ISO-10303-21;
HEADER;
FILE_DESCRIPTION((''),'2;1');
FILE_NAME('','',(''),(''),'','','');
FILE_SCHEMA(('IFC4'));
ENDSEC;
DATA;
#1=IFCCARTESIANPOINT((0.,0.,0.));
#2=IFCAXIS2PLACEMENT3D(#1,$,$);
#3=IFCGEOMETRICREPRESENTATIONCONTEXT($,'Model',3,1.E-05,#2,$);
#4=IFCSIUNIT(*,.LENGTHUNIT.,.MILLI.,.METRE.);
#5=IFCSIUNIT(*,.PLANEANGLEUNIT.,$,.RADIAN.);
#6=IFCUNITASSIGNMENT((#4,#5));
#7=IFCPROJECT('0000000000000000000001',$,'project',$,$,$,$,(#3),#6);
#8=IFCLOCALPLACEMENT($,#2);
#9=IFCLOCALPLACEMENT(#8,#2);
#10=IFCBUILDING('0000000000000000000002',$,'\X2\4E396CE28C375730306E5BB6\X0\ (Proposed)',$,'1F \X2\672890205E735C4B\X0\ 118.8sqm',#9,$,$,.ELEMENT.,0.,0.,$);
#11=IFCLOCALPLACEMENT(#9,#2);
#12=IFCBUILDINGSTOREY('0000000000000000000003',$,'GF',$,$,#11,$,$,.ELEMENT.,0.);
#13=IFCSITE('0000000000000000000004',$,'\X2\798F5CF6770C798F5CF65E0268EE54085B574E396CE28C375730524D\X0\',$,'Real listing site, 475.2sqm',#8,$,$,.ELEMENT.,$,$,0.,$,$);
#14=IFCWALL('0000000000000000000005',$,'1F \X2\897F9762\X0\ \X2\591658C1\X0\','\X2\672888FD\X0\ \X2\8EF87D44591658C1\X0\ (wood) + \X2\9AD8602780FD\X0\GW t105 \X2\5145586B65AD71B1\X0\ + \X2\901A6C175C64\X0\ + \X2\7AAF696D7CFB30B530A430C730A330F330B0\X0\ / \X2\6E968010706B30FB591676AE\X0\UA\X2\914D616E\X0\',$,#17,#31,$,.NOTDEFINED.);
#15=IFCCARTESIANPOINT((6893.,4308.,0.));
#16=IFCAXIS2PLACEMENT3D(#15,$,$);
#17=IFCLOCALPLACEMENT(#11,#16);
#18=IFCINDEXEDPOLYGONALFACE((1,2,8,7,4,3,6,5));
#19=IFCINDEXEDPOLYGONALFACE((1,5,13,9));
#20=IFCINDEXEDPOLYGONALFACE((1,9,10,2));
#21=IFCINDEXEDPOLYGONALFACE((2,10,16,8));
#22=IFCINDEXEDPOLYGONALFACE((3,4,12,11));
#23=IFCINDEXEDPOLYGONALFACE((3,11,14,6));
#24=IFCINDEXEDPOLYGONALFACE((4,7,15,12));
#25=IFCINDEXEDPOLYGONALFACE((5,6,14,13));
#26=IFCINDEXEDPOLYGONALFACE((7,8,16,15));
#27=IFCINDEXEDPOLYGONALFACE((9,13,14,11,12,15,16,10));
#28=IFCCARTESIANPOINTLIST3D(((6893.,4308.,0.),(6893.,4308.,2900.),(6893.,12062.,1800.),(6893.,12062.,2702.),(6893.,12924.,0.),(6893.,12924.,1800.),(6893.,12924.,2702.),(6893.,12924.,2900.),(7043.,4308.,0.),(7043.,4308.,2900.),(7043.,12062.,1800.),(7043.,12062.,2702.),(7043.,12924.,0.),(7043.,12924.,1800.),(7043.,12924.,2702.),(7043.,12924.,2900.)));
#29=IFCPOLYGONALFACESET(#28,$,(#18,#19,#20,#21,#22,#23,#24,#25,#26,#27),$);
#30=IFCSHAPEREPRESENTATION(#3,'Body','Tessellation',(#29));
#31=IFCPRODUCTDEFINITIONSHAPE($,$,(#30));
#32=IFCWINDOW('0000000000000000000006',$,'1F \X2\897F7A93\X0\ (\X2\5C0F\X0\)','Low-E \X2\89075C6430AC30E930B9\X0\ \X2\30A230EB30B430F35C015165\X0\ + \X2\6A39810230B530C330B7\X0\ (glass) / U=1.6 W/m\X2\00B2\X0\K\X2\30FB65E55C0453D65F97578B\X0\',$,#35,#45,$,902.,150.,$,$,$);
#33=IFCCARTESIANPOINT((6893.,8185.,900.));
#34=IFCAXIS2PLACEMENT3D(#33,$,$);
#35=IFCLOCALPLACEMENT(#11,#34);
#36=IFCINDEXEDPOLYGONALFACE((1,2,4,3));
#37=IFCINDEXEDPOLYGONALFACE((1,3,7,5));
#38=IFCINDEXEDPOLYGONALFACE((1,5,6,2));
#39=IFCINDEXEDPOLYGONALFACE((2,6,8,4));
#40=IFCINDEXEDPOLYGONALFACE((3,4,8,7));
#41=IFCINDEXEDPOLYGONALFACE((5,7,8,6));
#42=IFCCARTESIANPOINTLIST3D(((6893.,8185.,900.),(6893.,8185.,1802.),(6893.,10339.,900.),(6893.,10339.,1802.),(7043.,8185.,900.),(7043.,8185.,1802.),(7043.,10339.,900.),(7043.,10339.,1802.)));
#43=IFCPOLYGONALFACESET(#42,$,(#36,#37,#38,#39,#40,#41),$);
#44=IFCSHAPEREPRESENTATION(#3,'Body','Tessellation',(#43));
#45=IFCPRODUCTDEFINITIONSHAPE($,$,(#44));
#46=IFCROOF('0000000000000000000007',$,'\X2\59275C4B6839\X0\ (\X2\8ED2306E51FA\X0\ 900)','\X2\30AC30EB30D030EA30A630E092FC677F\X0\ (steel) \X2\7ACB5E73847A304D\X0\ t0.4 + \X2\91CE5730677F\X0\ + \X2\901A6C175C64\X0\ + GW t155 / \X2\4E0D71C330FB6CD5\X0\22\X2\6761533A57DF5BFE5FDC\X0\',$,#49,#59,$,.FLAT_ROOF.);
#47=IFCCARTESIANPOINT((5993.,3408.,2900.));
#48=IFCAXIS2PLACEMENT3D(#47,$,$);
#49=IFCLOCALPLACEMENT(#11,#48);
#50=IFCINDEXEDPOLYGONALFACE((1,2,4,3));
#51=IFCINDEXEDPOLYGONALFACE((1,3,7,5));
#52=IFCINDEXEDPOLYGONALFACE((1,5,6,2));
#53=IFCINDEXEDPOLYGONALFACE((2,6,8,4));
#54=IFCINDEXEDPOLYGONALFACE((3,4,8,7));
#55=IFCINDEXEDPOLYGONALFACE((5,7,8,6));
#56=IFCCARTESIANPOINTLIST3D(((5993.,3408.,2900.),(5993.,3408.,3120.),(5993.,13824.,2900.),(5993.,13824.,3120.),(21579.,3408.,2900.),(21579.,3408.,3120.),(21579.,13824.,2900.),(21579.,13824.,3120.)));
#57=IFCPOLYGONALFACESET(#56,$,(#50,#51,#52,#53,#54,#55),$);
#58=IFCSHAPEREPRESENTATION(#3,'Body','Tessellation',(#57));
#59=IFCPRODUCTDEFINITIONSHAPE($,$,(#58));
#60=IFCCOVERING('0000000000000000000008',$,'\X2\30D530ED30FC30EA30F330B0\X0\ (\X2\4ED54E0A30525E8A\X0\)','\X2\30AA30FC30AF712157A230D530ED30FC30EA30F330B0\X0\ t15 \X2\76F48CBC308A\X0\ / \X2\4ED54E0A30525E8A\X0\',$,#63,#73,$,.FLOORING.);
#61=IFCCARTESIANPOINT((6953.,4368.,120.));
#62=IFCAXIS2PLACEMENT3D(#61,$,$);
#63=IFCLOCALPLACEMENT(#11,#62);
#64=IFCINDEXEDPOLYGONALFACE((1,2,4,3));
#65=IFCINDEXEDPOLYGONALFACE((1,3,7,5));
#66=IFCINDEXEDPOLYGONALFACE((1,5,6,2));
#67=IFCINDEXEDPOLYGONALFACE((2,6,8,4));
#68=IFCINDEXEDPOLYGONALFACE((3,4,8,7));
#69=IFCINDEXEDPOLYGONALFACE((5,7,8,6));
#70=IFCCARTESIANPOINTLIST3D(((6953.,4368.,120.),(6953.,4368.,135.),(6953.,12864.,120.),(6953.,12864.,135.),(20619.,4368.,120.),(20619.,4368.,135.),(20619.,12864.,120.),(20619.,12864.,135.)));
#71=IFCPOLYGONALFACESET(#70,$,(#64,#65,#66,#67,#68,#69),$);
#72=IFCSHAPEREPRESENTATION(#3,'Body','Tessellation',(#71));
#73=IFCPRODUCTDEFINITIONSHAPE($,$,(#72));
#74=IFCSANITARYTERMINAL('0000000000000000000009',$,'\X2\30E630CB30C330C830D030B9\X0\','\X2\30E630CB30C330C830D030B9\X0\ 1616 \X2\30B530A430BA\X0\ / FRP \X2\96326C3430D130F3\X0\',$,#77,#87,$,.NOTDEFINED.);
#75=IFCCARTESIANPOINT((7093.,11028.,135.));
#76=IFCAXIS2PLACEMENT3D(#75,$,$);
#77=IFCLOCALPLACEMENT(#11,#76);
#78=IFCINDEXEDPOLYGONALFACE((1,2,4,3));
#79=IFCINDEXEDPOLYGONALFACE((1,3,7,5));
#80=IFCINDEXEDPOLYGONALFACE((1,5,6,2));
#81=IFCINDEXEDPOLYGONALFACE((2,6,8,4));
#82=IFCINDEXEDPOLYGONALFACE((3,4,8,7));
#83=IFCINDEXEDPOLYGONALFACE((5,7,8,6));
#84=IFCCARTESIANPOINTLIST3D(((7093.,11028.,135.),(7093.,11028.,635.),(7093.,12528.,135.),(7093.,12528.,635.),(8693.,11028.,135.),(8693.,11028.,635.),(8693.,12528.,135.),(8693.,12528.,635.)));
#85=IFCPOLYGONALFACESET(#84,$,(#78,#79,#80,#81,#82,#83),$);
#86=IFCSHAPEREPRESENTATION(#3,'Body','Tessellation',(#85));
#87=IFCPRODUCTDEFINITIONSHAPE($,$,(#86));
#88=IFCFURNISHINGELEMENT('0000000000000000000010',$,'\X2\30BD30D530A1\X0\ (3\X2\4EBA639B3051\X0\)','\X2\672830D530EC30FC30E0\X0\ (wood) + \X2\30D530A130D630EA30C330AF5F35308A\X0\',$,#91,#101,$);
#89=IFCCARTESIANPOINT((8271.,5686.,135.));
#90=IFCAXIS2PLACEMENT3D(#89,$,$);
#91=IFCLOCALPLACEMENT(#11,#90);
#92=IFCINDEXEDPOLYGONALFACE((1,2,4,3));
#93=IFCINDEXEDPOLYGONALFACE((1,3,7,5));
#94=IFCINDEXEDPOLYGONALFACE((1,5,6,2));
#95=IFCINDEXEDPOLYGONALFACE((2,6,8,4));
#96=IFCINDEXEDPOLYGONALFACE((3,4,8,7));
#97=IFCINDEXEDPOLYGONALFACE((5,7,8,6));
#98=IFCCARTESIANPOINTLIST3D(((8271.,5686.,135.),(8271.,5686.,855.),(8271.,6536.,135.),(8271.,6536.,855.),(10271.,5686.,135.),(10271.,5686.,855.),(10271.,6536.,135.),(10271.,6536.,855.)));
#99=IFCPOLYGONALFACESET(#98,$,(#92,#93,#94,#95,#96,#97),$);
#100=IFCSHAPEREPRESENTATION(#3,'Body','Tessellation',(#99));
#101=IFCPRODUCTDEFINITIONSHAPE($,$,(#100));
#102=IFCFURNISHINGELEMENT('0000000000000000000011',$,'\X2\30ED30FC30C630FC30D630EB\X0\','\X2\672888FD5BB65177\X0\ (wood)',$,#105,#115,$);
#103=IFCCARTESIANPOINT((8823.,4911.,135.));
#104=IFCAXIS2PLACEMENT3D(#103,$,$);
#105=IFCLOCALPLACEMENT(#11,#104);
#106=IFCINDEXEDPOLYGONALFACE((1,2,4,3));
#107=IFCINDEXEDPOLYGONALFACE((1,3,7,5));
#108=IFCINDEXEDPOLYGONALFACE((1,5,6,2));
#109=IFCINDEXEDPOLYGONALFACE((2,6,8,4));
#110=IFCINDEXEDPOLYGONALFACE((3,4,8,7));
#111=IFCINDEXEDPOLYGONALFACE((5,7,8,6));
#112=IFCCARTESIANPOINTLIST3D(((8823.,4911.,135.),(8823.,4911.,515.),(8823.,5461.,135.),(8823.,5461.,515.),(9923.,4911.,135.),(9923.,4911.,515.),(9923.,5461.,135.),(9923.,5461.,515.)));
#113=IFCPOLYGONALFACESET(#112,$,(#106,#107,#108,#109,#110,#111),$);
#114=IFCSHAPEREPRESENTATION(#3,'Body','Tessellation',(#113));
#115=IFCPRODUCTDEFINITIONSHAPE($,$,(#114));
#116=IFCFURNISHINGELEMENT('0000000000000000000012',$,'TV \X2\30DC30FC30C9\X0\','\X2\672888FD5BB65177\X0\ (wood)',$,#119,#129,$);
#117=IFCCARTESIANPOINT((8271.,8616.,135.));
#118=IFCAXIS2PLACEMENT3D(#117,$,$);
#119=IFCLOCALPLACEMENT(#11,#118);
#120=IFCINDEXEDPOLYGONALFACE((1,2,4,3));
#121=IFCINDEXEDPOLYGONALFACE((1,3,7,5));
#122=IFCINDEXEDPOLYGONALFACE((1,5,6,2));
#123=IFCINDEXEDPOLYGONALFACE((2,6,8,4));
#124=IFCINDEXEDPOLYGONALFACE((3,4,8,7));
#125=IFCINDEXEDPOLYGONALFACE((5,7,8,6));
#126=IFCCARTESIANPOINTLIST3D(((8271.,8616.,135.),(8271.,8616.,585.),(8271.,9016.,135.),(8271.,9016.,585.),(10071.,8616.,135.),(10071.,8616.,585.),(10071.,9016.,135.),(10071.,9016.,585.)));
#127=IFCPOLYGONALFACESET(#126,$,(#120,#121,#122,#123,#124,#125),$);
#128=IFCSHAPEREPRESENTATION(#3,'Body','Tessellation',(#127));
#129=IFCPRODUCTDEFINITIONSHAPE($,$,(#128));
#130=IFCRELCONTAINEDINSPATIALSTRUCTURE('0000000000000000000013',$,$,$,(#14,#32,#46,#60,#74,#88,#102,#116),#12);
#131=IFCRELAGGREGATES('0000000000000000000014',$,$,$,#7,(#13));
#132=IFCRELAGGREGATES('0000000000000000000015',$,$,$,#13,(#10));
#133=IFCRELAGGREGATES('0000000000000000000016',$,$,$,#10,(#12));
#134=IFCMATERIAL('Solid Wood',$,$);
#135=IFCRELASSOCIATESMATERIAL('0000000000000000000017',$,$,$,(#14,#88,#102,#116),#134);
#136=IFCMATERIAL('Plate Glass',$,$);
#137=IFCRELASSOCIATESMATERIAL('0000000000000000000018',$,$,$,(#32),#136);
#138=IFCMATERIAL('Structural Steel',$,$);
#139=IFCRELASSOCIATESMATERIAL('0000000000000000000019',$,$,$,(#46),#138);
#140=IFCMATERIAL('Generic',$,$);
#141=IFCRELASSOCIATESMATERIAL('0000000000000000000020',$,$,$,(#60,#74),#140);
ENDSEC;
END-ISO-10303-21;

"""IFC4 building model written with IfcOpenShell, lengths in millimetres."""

from ifc_helpers import new_model, si_unit, frame, frame_2d, origin, place, context, project, spatial, rectangle, extrude, material, element, fill, save


model = new_model("IFC4")

# Units and contexts
model_context = context("Model", 3, precision=1e-05, world=origin())
ifc_project = project(units=[si_unit("LENGTHUNIT", "METRE", prefix="MILLI"), si_unit("PLANEANGLEUNIT", "RADIAN")], contexts=[model_context])

# Site, building, storey
site_placement = place(None, origin())
site = spatial("IfcSite", under=ifc_project, at=site_placement, Name="福島県福島市森合字丹波谷地前", ObjectType="Real listing site, 475.2sqm", CompositionType="ELEMENT", RefElevation=0.0)
building_placement = place(site_placement, origin())
building = spatial("IfcBuilding", under=site, at=building_placement, Name="丹波谷地の家 (Proposed)", ObjectType="1F 木造平屋 118.8sqm", CompositionType="ELEMENT", ElevationOfRefHeight=0.0, ElevationOfTerrain=0.0)
storey_placement = place(building_placement, origin())
storey = spatial("IfcBuildingStorey", under=building, at=storey_placement, Name="GF", CompositionType="ELEMENT", Elevation=0.0)

# Shared definitions
ifc_material_1 = material(Name="Solid Wood")

# Shared definitions
ifc_material_2 = material(Name="Plate Glass")

# Wall, opening, window
wall_1_placement = place(storey_placement, frame((6893.0, 4308.0, 0.0)))
wall_1 = element("IfcWall", 1, at=wall_1_placement, inside=storey, material=ifc_material_1, Name="1F 西面 外壁", Description="木製 軸組外壁 (wood) + 高性能GW t105 充填断熱 + 通気層 + 窯業系サイディング / 準耐火・外皮UA配慮", PredefinedType="NOTDEFINED", context=model_context, shape_type="SweptSolid", body=[
    extrude(rectangle(XDim=150.0, YDim=8616.0, at=frame_2d((75.0, 4308.0))), frame((6893.0, 4308.0, 0.0)), (0.0, 0.0, 1.0), 2900.0),
])
opening_1_placement = place(storey_placement, frame((6893.0, 8185.0, 900.0)))
opening_1 = element("IfcOpeningElement", 2, at=opening_1_placement, cuts=wall_1, PredefinedType="NOTDEFINED", context=model_context, shape_type="SweptSolid", body=[
    extrude(rectangle(XDim=150.0, YDim=2154.0, at=frame_2d((75.0, 1077.0))), frame((6893.0, 8185.0, 900.0)), (0.0, 0.0, 1.0), 902.0),
])
window_1_placement = place(storey_placement, frame((6893.0, 8185.0, 900.0)))
window_1 = element("IfcWindow", 3, at=window_1_placement, inside=storey, material=ifc_material_2, Name="1F 西窓 (小)", Description="Low-E 複層ガラス アルゴン封入 + 樹脂サッシ (glass) / U=1.6 W/m²K・日射取得型", OverallHeight=902.0, OverallWidth=150.0, context=model_context, shape_type="SweptSolid", body=[
    extrude(rectangle(XDim=150.0, YDim=2154.0, at=frame_2d((75.0, 1077.0))), frame((6893.0, 8185.0, 900.0)), (0.0, 0.0, 1.0), 902.0),
])
fill(opening_1, window_1)

# Roof
ifc_material_3 = material(Name="Structural Steel")
roof_placement = place(storey_placement, frame((5993.0, 3408.0, 2900.0)))
element("IfcRoof", 4, at=roof_placement, inside=storey, material=ifc_material_3, Name="大屋根 (軒の出 900)", Description="ガルバリウム鋼板 (steel) 立平葺き t0.4 + 野地板 + 通気層 + GW t155 / 不燃・法22条区域対応", PredefinedType="FLAT_ROOF", context=model_context, shape_type="SweptSolid", body=[
    extrude(rectangle(XDim=15586.0, YDim=10416.0, at=frame_2d((7793.0, 5208.0))), frame((5993.0, 3408.0, 2900.0)), (0.0, 0.0, 1.0), 220.0),
])

# Covering
ifc_material_4 = material(Name="Generic")
covering_placement = place(storey_placement, frame((6953.0, 4368.0, 120.0)))
element("IfcCovering", 5, at=covering_placement, inside=storey, material=ifc_material_4, Name="フローリング (仕上げ床)", Description="オーク無垢フローリング t15 直貼り / 仕上げ床", PredefinedType="FLOORING", context=model_context, shape_type="SweptSolid", body=[
    extrude(rectangle(XDim=13666.0, YDim=8496.0, at=frame_2d((6833.0, 4248.0))), frame((6953.0, 4368.0, 120.0)), (0.0, 0.0, 1.0), 15.0),
])

# Sanitary terminal
sanitary_terminal_placement = place(storey_placement, frame((7093.0, 11028.0, 135.0)))
element("IfcSanitaryTerminal", 6, at=sanitary_terminal_placement, inside=storey, material=ifc_material_4, Name="ユニットバス", Description="ユニットバス 1616 サイズ / FRP 防水パン", PredefinedType="NOTDEFINED", context=model_context, shape_type="SweptSolid", body=[
    extrude(rectangle(XDim=1600.0, YDim=1500.0, at=frame_2d((800.0, 750.0))), frame((7093.0, 11028.0, 135.0)), (0.0, 0.0, 1.0), 500.0),
])

# Furnishing elements
furnishing_1_placement = place(storey_placement, frame((8271.0, 5686.0, 135.0)))
element("IfcFurnishingElement", 7, at=furnishing_1_placement, inside=storey, material=ifc_material_1, Name="ソファ (3人掛け)", Description="木フレーム (wood) + ファブリック張り", context=model_context, shape_type="SweptSolid", body=[
    extrude(rectangle(XDim=2000.0, YDim=850.0, at=frame_2d((1000.0, 425.0))), frame((8271.0, 5686.0, 135.0)), (0.0, 0.0, 1.0), 720.0),
])
furnishing_2_placement = place(storey_placement, frame((8823.0, 4911.0, 135.0)))
element("IfcFurnishingElement", 8, at=furnishing_2_placement, inside=storey, material=ifc_material_1, Name="ローテーブル", Description="木製家具 (wood)", context=model_context, shape_type="SweptSolid", body=[
    extrude(rectangle(XDim=1100.0, YDim=550.0, at=frame_2d((550.0, 275.0))), frame((8823.0, 4911.0, 135.0)), (0.0, 0.0, 1.0), 380.0),
])
furnishing_3_placement = place(storey_placement, frame((8271.0, 8616.0, 135.0)))
element("IfcFurnishingElement", 9, at=furnishing_3_placement, inside=storey, material=ifc_material_1, Name="TV ボード", Description="木製家具 (wood)", context=model_context, shape_type="SweptSolid", body=[
    extrude(rectangle(XDim=1800.0, YDim=400.0, at=frame_2d((900.0, 200.0))), frame((8271.0, 8616.0, 135.0)), (0.0, 0.0, 1.0), 450.0),
])

save(model, "model.ifc")
